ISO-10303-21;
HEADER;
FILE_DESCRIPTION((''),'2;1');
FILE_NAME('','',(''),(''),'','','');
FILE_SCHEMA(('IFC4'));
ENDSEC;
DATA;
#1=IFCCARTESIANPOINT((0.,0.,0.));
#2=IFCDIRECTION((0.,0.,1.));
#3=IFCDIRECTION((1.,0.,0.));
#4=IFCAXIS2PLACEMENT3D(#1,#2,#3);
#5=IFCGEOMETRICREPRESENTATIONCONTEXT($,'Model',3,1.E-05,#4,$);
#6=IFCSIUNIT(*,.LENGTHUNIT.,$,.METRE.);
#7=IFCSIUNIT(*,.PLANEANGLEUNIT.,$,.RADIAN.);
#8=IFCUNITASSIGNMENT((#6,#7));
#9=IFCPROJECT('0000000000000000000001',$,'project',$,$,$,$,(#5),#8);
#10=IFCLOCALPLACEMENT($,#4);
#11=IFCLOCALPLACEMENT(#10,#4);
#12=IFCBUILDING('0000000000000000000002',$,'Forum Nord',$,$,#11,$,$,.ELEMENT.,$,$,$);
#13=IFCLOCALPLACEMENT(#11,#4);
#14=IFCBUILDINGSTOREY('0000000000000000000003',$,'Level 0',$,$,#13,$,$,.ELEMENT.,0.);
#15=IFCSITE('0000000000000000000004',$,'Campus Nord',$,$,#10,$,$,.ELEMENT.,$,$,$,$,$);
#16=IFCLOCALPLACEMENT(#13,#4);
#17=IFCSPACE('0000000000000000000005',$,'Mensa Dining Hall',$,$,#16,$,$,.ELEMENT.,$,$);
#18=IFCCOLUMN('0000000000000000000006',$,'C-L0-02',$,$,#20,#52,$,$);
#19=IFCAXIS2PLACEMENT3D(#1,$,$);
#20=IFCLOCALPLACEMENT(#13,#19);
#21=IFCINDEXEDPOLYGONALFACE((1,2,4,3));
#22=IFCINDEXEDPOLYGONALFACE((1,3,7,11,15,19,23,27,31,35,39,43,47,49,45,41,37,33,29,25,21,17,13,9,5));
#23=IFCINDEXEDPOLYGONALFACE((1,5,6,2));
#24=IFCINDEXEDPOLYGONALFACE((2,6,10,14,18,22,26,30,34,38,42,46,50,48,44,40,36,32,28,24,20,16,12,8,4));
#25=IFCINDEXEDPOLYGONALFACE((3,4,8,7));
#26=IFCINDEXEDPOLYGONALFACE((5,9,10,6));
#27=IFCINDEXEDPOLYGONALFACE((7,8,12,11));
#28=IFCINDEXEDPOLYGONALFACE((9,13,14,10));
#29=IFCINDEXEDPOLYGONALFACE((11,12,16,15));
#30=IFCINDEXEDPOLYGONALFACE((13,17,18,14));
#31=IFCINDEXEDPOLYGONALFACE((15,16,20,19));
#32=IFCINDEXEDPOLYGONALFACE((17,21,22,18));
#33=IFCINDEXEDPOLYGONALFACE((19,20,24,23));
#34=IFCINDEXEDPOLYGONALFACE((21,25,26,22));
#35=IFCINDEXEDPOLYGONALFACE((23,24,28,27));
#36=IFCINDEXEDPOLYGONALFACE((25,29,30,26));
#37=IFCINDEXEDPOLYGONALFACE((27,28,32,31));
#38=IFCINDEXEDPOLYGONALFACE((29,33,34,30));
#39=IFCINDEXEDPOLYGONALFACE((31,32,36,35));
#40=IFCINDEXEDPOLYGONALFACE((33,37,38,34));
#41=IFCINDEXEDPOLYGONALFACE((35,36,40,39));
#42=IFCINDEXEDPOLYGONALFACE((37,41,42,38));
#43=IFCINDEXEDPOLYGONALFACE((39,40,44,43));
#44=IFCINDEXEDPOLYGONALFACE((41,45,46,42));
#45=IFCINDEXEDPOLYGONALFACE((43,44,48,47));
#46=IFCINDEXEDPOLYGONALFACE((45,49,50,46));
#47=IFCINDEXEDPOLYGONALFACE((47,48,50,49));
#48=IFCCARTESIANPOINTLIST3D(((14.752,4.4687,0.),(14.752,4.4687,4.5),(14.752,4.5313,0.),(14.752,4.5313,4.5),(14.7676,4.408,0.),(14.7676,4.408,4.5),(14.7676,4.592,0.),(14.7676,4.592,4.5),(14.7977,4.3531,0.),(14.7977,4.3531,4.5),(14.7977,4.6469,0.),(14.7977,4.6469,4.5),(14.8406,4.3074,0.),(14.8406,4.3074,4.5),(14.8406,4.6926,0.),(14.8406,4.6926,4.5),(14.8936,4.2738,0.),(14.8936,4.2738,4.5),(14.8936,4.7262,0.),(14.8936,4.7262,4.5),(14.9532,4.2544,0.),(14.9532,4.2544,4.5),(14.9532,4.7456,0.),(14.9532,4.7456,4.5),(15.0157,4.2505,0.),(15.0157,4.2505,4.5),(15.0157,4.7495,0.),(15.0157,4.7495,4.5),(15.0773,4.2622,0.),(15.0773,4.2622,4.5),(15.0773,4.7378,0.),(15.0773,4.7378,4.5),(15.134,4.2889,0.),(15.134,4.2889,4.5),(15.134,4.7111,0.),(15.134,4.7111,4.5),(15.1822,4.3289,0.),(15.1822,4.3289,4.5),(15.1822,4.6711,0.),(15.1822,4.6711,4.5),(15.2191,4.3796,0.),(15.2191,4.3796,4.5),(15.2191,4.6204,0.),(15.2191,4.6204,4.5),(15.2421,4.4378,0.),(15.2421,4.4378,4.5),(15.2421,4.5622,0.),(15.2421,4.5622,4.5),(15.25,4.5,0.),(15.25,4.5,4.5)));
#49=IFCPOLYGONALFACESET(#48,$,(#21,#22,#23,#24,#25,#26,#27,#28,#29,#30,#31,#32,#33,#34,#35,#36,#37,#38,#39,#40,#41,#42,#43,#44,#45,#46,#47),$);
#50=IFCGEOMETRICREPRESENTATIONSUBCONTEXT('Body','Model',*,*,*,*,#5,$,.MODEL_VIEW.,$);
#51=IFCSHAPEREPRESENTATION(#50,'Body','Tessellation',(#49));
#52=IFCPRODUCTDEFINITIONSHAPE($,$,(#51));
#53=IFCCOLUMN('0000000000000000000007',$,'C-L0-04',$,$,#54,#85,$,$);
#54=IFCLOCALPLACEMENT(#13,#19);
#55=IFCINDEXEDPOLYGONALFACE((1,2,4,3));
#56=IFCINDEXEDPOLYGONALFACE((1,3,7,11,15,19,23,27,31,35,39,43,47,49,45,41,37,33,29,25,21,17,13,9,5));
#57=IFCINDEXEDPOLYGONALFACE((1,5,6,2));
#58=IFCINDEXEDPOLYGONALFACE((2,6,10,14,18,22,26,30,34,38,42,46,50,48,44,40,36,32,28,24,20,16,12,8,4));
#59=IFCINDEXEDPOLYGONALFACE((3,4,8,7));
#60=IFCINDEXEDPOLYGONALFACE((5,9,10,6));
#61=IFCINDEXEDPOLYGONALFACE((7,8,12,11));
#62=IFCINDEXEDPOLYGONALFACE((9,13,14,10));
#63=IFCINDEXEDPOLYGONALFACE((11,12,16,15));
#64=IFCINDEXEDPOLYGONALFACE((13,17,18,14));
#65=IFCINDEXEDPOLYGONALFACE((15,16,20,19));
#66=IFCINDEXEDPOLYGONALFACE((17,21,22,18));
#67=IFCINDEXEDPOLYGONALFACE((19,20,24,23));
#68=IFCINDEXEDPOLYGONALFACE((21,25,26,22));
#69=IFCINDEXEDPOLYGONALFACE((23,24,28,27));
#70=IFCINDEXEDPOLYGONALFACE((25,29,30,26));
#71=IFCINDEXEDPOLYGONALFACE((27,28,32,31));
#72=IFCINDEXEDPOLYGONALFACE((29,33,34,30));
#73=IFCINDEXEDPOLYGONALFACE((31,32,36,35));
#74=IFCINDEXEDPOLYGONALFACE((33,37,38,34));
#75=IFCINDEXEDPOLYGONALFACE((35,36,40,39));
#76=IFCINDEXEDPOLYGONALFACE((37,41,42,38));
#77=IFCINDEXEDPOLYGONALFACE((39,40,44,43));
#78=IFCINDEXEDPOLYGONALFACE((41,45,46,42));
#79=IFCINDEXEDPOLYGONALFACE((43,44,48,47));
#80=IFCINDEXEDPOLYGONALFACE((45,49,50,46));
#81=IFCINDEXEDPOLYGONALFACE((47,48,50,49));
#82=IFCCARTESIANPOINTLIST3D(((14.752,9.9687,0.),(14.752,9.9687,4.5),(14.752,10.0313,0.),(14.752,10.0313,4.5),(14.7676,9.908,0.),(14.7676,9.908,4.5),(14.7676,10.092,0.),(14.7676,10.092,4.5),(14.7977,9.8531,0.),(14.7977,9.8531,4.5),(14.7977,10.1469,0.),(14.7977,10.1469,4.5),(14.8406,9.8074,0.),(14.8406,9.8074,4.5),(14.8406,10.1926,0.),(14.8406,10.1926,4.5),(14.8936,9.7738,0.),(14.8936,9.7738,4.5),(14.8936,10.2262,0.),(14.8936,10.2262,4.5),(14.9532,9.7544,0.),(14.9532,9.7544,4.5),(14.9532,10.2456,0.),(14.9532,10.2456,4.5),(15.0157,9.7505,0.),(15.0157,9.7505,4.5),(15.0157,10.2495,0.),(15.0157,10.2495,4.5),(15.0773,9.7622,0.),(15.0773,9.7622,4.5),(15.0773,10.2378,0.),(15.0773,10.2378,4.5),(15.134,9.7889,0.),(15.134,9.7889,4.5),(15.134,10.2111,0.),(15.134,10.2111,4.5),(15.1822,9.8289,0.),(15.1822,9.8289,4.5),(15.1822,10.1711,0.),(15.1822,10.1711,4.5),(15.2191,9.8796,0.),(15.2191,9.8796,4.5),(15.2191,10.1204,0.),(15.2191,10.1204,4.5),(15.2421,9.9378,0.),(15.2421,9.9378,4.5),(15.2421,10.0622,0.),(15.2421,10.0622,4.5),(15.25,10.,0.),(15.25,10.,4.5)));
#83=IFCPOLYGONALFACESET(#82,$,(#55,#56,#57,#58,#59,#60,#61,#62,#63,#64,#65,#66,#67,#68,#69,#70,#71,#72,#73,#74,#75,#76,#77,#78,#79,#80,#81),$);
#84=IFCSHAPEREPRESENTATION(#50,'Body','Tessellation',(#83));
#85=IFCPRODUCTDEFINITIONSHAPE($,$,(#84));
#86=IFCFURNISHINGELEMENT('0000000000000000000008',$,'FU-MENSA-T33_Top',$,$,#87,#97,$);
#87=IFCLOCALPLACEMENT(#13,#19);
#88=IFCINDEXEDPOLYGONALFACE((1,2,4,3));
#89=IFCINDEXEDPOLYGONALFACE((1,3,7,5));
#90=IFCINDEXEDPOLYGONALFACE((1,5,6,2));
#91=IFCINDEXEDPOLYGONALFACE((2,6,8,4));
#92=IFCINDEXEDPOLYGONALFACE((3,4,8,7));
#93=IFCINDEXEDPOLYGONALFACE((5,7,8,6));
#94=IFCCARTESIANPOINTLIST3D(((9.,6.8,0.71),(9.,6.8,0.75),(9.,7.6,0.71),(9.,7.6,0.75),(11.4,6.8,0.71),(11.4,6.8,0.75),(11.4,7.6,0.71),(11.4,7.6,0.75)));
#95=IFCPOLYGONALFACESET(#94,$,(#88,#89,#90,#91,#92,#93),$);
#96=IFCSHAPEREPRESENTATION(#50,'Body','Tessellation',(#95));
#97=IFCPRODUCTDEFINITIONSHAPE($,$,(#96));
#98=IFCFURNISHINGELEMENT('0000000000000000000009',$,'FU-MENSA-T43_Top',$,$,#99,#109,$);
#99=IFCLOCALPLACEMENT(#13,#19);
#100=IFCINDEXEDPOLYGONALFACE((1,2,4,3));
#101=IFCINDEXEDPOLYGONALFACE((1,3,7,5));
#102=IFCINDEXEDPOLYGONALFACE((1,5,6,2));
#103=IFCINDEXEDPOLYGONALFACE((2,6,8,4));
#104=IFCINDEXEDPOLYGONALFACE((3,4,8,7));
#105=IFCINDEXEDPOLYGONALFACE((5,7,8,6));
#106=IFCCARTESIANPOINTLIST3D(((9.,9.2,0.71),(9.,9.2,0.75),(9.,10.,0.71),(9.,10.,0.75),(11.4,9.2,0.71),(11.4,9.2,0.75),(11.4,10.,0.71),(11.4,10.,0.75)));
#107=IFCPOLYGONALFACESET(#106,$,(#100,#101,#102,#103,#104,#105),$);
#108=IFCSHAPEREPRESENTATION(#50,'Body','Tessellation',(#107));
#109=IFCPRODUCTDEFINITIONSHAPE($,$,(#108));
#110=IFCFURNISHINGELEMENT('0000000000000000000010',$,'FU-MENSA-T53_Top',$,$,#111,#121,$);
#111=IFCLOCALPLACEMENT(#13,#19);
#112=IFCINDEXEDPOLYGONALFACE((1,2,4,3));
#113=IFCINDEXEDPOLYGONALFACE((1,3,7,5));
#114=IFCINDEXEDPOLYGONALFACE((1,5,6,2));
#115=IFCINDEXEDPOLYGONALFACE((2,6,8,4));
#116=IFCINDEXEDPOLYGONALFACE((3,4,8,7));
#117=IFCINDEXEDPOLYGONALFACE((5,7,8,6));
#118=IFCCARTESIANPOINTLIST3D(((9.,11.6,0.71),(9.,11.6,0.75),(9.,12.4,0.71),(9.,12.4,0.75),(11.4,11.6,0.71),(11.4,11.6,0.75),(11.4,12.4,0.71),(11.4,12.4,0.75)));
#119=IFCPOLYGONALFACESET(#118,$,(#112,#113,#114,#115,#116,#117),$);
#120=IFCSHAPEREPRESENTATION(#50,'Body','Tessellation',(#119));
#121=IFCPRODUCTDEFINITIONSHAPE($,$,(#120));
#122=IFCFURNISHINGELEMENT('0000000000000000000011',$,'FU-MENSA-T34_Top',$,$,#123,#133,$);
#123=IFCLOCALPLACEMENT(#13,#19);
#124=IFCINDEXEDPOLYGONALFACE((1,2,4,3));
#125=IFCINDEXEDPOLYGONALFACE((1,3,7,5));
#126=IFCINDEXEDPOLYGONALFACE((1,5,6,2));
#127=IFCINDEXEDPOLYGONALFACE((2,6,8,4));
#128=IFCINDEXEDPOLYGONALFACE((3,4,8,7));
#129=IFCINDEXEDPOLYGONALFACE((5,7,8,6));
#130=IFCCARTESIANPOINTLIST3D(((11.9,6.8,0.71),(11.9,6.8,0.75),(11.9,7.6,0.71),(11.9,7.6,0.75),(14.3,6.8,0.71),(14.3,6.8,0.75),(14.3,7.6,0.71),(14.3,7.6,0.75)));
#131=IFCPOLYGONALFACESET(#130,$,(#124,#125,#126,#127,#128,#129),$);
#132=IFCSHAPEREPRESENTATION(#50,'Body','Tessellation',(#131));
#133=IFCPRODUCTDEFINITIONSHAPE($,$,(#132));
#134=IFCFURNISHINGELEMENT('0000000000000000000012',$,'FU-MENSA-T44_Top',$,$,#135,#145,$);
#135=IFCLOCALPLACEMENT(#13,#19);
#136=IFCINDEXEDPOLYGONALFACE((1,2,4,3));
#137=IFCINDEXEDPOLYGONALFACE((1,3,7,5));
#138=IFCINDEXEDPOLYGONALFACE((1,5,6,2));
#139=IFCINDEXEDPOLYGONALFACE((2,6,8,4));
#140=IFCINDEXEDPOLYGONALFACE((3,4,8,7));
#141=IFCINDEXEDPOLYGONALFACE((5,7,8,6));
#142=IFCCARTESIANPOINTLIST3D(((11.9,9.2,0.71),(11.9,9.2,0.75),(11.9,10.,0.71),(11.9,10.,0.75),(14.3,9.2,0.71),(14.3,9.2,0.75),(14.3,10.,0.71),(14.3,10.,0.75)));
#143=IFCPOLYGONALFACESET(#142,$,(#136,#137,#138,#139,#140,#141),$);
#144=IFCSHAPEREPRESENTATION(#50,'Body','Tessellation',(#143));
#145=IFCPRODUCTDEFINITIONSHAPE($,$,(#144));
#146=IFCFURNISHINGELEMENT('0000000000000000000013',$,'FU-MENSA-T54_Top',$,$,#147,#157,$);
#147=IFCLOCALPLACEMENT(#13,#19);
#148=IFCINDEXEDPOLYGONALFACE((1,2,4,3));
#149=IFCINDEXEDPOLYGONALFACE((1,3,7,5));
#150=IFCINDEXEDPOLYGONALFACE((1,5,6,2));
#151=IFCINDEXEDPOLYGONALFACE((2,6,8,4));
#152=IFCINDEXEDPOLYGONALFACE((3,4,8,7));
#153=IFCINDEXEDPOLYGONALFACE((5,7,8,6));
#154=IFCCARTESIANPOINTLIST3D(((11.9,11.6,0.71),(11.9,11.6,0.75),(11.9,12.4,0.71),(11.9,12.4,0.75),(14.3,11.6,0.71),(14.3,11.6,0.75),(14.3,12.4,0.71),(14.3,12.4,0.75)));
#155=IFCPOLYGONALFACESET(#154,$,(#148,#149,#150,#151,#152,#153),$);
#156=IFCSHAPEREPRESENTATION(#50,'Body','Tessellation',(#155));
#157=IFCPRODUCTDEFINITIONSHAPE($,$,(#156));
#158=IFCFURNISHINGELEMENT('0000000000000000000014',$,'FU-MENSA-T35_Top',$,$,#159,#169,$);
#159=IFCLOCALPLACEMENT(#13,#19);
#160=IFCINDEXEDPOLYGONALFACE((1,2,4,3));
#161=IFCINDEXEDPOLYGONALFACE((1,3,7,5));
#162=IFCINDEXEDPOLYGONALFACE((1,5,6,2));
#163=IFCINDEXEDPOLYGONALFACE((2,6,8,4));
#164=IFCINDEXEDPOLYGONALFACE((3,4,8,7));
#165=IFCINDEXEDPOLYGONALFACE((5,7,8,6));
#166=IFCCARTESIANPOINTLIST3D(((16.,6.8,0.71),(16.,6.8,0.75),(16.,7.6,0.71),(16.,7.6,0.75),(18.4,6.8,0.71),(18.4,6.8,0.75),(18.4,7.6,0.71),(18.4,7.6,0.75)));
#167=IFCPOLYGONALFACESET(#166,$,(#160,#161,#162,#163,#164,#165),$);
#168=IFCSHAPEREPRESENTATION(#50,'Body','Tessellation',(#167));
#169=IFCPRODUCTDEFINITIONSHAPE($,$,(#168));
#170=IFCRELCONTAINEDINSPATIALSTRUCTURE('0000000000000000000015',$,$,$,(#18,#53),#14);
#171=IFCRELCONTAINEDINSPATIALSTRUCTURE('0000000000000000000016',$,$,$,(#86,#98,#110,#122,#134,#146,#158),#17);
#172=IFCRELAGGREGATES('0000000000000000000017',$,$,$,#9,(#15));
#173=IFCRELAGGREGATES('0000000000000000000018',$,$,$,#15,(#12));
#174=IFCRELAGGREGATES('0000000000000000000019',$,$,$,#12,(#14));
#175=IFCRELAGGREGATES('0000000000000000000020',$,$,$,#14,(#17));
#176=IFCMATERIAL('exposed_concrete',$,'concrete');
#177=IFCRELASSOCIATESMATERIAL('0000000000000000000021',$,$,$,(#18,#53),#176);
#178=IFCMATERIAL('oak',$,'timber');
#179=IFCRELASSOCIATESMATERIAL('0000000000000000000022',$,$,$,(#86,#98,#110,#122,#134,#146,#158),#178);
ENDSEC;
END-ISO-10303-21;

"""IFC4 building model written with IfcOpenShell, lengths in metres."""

from ifc_helpers import new_model, si_unit, frame, frame_2d, origin_with_axes, origin_2d_with_axis, place, context, subcontext, project, spatial, rectangle, circle, extrude, material, element, save


model = new_model("IFC4")

# Units and contexts
model_context = context("Model", 3, precision=1e-05, world=origin_with_axes())
body_context = subcontext(model_context, "Body", "Model", "MODEL_VIEW")
ifc_project = project(units=[si_unit("LENGTHUNIT", "METRE"), si_unit("PLANEANGLEUNIT", "RADIAN")], contexts=[model_context])

# Site, building, storey
site_placement = place(None, origin_with_axes())
site = spatial("IfcSite", under=ifc_project, at=site_placement, Name="Campus Nord", CompositionType="ELEMENT")
building_placement = place(site_placement, origin_with_axes())
building = spatial("IfcBuilding", under=site, at=building_placement, Name="Forum Nord", CompositionType="ELEMENT")
storey_placement = place(building_placement, origin_with_axes())
storey = spatial("IfcBuildingStorey", under=building, at=storey_placement, Name="Level 0", CompositionType="ELEMENT", Elevation=0.0)

# Columns
ifc_material_1 = material(Name="exposed_concrete", Category="concrete")
for number, where, z_axis, x_axis, name in (
    (1, (15.0, 4.5, 0.0), (0.0, 0.0, 1.0), (1.0, 0.0, 0.0), "C-L0-02"),
    (2, (15.0, 10.0, 0.0), (0.0, 0.0, 1.0), (1.0, 0.0, 0.0), "C-L0-04"),
):
    element("IfcColumn", number, at=place(storey_placement, frame(where, z_axis=z_axis, x_axis=x_axis)), inside=storey, material=ifc_material_1, Name=name, context=body_context, shape_type="SweptSolid", body=[
        extrude(circle(Radius=0.25, at=origin_2d_with_axis()), origin_with_axes(), (0.0, 0.0, 1.0), 4.5),
    ])

# Shared definitions
space_placement = place(storey_placement, origin_with_axes())
space = spatial("IfcSpace", under=storey, at=space_placement, Name="Mensa Dining Hall", CompositionType="ELEMENT")

# Furnishing elements
ifc_material_2 = material(Name="oak", Category="timber")
furnishing_1_placement = place(storey_placement, frame((9.0, 6.8, 0.0), z_axis=(0.0, 0.0, 1.0), x_axis=(1.0, 0.0, 0.0)))
element("IfcFurnishingElement", 3, at=furnishing_1_placement, inside=space, material=ifc_material_2, Name="FU-MENSA-T33_Top", context=body_context, shape_type="SweptSolid", body=[
    extrude(rectangle(XDim=2.4, YDim=0.8, at=frame_2d((1.2, 0.4), x_axis=(1.0, 0.0))), frame((0.0, 0.0, 0.71), z_axis=(0.0, 0.0, 1.0), x_axis=(1.0, 0.0, 0.0)), (0.0, 0.0, 1.0), 0.04),
])
furnishing_2_placement = place(storey_placement, frame((9.0, 9.2, 0.0), z_axis=(0.0, 0.0, 1.0), x_axis=(1.0, 0.0, 0.0)))
element("IfcFurnishingElement", 4, at=furnishing_2_placement, inside=space, material=ifc_material_2, Name="FU-MENSA-T43_Top", context=body_context, shape_type="SweptSolid", body=[
    extrude(rectangle(XDim=2.4, YDim=0.8, at=frame_2d((1.2, 0.4), x_axis=(1.0, 0.0))), frame((0.0, 0.0, 0.71), z_axis=(0.0, 0.0, 1.0), x_axis=(1.0, 0.0, 0.0)), (0.0, 0.0, 1.0), 0.04),
])
furnishing_3_placement = place(storey_placement, frame((9.0, 11.6, 0.0), z_axis=(0.0, 0.0, 1.0), x_axis=(1.0, 0.0, 0.0)))
element("IfcFurnishingElement", 5, at=furnishing_3_placement, inside=space, material=ifc_material_2, Name="FU-MENSA-T53_Top", context=body_context, shape_type="SweptSolid", body=[
    extrude(rectangle(XDim=2.4, YDim=0.8, at=frame_2d((1.2, 0.4), x_axis=(1.0, 0.0))), frame((0.0, 0.0, 0.71), z_axis=(0.0, 0.0, 1.0), x_axis=(1.0, 0.0, 0.0)), (0.0, 0.0, 1.0), 0.04),
])
furnishing_4_placement = place(storey_placement, frame((11.9, 6.8, 0.0), z_axis=(0.0, 0.0, 1.0), x_axis=(1.0, 0.0, 0.0)))
element("IfcFurnishingElement", 6, at=furnishing_4_placement, inside=space, material=ifc_material_2, Name="FU-MENSA-T34_Top", context=body_context, shape_type="SweptSolid", body=[
    extrude(rectangle(XDim=2.4, YDim=0.8, at=frame_2d((1.2, 0.4), x_axis=(1.0, 0.0))), frame((0.0, 0.0, 0.71), z_axis=(0.0, 0.0, 1.0), x_axis=(1.0, 0.0, 0.0)), (0.0, 0.0, 1.0), 0.04),
])
furnishing_5_placement = place(storey_placement, frame((11.9, 9.2, 0.0), z_axis=(0.0, 0.0, 1.0), x_axis=(1.0, 0.0, 0.0)))
element("IfcFurnishingElement", 7, at=furnishing_5_placement, inside=space, material=ifc_material_2, Name="FU-MENSA-T44_Top", context=body_context, shape_type="SweptSolid", body=[
    extrude(rectangle(XDim=2.4, YDim=0.8, at=frame_2d((1.2, 0.4), x_axis=(1.0, 0.0))), frame((0.0, 0.0, 0.71), z_axis=(0.0, 0.0, 1.0), x_axis=(1.0, 0.0, 0.0)), (0.0, 0.0, 1.0), 0.04),
])
furnishing_6_placement = place(storey_placement, frame((11.9, 11.6, 0.0), z_axis=(0.0, 0.0, 1.0), x_axis=(1.0, 0.0, 0.0)))
element("IfcFurnishingElement", 8, at=furnishing_6_placement, inside=space, material=ifc_material_2, Name="FU-MENSA-T54_Top", context=body_context, shape_type="SweptSolid", body=[
    extrude(rectangle(XDim=2.4, YDim=0.8, at=frame_2d((1.2, 0.4), x_axis=(1.0, 0.0))), frame((0.0, 0.0, 0.71), z_axis=(0.0, 0.0, 1.0), x_axis=(1.0, 0.0, 0.0)), (0.0, 0.0, 1.0), 0.04),
])
furnishing_7_placement = place(storey_placement, frame((16.0, 6.8, 0.0), z_axis=(0.0, 0.0, 1.0), x_axis=(1.0, 0.0, 0.0)))
element("IfcFurnishingElement", 9, at=furnishing_7_placement, inside=space, material=ifc_material_2, Name="FU-MENSA-T35_Top", context=body_context, shape_type="SweptSolid", body=[
    extrude(rectangle(XDim=2.4, YDim=0.8, at=frame_2d((1.2, 0.4), x_axis=(1.0, 0.0))), frame((0.0, 0.0, 0.71), z_axis=(0.0, 0.0, 1.0), x_axis=(1.0, 0.0, 0.0)), (0.0, 0.0, 1.0), 0.04),
])

save(model, "model.ifc")
